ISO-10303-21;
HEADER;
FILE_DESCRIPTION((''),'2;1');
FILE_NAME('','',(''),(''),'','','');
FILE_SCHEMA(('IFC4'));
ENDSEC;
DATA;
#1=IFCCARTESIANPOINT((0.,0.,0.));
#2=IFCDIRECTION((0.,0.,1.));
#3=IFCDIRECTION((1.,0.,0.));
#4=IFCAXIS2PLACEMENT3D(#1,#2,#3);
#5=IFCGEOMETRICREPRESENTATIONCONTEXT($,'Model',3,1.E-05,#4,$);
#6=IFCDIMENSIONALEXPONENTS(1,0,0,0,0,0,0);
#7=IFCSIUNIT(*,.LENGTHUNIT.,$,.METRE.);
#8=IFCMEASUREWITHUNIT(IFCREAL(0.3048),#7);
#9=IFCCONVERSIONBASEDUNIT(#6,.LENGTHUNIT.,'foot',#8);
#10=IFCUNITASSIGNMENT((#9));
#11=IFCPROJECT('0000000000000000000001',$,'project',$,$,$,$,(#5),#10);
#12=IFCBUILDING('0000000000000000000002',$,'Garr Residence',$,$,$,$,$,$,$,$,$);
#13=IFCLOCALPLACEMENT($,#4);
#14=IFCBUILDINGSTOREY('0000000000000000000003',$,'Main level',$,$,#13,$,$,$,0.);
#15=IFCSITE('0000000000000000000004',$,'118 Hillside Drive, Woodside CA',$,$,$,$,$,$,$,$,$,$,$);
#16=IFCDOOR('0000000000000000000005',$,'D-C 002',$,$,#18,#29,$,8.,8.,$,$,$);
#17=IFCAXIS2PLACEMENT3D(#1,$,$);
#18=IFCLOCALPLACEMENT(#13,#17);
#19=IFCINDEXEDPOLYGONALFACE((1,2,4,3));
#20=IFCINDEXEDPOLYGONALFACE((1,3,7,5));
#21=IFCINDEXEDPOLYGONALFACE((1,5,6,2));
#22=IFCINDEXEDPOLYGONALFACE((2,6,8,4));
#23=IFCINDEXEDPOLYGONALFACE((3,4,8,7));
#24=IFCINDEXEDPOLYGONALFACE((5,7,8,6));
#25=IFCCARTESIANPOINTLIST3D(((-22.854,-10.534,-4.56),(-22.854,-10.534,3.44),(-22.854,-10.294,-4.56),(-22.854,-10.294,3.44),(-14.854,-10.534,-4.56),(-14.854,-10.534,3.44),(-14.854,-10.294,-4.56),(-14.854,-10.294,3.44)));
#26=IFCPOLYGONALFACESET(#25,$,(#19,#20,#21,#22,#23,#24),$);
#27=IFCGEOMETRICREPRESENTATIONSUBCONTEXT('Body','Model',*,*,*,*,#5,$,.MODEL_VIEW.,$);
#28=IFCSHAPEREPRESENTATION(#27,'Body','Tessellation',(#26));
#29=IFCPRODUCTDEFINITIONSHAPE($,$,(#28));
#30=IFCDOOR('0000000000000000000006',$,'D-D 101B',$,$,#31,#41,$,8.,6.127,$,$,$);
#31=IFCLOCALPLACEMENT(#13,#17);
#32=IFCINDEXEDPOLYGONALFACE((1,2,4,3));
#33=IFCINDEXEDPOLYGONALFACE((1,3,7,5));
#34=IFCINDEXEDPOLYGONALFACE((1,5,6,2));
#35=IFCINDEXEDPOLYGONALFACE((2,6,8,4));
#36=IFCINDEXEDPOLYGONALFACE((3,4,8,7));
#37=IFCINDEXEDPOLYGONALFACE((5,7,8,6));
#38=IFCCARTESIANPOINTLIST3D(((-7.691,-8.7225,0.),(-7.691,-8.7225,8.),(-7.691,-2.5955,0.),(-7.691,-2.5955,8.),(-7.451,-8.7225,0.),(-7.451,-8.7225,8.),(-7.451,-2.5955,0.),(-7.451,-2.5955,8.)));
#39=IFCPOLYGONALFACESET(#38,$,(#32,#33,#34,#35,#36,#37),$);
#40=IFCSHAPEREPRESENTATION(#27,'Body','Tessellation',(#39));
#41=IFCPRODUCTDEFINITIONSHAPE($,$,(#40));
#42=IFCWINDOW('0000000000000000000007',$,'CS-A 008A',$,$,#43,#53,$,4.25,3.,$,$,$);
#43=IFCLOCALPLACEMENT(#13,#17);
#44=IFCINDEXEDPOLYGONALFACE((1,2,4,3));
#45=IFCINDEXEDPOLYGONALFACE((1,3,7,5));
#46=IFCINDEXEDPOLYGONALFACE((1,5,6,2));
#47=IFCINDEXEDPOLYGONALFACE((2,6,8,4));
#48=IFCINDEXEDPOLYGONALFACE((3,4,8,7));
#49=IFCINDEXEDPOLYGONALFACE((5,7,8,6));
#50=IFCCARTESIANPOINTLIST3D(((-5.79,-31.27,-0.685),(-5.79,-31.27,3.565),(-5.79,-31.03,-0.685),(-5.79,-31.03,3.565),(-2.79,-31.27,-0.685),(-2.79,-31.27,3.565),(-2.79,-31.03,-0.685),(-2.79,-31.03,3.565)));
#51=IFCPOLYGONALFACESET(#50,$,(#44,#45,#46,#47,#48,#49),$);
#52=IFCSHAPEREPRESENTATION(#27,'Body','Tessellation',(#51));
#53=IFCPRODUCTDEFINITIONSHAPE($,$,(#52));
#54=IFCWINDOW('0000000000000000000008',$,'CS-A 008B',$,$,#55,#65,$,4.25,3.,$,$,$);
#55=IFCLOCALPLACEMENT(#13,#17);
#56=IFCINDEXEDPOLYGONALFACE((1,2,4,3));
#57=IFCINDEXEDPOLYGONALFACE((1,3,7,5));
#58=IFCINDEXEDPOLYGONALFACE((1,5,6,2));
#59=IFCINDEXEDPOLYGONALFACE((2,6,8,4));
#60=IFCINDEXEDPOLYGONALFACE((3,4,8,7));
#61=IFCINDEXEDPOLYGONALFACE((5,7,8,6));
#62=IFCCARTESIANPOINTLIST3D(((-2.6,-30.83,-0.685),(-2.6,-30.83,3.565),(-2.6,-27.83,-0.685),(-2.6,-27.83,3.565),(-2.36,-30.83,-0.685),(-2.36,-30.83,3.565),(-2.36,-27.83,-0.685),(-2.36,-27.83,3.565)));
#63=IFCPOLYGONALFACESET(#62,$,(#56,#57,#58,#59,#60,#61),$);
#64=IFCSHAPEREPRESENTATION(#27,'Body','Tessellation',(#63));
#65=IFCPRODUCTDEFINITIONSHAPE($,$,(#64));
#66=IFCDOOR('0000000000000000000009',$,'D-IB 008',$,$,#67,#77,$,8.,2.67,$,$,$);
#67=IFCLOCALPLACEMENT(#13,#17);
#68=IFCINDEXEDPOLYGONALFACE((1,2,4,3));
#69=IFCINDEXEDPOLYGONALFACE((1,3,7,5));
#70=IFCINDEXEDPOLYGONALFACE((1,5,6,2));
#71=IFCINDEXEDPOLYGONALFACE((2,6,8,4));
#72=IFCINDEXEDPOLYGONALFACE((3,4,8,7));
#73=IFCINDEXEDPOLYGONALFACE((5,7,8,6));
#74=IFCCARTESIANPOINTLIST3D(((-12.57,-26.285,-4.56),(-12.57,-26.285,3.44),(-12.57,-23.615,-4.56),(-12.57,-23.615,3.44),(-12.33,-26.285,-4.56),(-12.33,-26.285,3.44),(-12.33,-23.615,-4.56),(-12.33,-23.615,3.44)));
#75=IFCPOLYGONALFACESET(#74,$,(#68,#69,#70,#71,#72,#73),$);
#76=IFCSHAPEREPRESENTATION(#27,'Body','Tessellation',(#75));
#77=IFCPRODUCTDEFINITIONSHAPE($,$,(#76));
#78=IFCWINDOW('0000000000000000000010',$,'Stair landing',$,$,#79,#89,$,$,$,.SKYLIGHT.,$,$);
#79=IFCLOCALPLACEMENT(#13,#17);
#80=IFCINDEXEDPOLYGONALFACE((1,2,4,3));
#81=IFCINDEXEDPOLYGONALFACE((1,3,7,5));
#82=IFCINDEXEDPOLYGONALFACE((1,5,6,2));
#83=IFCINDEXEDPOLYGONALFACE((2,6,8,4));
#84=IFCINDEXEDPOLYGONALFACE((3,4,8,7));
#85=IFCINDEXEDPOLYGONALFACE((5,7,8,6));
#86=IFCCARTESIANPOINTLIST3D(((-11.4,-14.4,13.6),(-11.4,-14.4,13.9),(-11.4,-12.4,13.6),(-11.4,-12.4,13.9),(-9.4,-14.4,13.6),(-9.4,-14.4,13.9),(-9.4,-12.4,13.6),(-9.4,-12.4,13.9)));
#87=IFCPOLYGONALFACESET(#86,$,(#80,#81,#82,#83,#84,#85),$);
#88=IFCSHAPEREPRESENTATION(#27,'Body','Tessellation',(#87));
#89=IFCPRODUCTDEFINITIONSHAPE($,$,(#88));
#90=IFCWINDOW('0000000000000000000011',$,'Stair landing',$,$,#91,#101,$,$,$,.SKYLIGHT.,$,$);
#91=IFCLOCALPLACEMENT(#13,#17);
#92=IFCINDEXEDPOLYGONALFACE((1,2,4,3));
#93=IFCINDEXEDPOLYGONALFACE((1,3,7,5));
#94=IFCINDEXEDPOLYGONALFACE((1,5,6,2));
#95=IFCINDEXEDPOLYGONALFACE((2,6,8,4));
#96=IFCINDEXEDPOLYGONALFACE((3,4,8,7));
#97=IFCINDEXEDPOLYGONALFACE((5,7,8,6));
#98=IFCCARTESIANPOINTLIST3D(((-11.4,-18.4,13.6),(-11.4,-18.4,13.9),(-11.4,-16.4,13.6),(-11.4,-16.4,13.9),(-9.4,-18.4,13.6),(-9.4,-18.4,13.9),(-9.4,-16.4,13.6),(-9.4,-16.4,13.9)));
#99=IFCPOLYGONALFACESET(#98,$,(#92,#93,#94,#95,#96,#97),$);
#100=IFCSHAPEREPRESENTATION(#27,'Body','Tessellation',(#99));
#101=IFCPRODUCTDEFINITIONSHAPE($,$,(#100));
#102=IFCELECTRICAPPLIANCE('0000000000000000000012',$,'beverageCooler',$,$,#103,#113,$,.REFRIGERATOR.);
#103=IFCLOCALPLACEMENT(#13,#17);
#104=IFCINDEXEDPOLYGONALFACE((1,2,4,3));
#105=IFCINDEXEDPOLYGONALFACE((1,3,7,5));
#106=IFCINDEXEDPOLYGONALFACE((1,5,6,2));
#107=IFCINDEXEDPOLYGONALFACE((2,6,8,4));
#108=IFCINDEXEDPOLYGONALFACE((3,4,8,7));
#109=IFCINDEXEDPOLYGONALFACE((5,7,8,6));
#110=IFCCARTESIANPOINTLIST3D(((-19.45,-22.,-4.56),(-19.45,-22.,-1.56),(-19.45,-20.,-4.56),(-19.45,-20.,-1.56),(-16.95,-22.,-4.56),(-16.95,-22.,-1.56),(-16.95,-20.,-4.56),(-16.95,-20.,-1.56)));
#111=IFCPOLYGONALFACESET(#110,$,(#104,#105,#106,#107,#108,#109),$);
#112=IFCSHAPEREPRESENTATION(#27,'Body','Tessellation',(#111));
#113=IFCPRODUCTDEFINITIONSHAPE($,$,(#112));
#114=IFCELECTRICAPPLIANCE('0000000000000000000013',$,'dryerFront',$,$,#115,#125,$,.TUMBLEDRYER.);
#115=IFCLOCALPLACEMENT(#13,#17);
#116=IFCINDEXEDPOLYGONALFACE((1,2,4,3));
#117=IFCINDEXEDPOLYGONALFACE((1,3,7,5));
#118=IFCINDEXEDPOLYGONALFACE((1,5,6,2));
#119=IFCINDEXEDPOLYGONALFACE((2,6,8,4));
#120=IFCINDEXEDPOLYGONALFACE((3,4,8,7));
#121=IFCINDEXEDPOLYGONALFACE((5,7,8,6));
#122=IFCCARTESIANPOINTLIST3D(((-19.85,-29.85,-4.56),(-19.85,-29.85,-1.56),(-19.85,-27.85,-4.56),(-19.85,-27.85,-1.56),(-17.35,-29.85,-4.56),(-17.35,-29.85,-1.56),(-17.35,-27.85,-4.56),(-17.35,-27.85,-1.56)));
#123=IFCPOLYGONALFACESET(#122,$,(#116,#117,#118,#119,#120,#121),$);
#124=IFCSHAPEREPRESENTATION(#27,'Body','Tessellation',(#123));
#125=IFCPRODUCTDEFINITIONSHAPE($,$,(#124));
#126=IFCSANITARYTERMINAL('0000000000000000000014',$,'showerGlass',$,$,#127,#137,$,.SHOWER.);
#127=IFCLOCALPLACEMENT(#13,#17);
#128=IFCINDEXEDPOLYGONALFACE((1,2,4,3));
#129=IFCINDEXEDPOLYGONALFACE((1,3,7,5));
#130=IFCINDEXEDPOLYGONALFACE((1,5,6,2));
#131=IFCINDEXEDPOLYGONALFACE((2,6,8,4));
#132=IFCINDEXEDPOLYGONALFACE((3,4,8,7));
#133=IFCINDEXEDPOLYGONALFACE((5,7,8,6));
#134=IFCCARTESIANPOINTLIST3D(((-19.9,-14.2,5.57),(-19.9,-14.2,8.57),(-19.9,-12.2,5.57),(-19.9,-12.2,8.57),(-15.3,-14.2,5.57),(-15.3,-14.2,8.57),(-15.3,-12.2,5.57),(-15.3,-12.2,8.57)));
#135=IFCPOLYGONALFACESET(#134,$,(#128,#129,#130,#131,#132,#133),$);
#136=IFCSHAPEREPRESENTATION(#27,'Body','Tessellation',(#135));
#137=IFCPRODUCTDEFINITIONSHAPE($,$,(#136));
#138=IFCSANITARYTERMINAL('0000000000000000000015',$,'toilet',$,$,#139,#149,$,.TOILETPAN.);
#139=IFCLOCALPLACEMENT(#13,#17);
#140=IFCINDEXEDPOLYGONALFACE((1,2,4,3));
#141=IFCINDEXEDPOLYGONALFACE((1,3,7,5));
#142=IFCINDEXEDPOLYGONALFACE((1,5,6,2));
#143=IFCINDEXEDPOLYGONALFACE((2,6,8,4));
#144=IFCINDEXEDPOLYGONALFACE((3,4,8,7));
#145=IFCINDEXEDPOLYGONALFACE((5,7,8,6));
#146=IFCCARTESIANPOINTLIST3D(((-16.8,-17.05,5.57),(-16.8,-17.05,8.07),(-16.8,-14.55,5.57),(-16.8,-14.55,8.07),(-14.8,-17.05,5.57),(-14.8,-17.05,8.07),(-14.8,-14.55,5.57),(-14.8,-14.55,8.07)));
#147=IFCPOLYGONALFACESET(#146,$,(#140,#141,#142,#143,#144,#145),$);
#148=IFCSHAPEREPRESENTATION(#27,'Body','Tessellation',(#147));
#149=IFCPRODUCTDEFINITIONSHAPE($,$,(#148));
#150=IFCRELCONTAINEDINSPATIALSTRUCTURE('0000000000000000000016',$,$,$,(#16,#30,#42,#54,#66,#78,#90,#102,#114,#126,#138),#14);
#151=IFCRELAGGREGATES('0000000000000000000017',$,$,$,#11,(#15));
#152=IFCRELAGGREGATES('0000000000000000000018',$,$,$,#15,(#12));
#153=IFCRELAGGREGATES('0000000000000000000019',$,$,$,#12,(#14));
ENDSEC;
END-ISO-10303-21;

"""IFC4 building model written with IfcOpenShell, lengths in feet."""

from ifc_helpers import new_model, entity, si_unit, converted_unit, frame, origin, origin_with_axes, place, context, subcontext, project, spatial, polyline, outline, extrude, element, save


model = new_model("IFC4")

# Units and contexts
model_context = context("Model", 3, precision=1e-05, world=origin_with_axes())
body_context = subcontext(model_context, "Body", "Model", "MODEL_VIEW")
ifc_project = project(units=[converted_unit("LENGTHUNIT", "foot", entity("IfcReal", 0.3048), si_unit("LENGTHUNIT", "METRE"), dimensions=[1, 0, 0, 0, 0, 0, 0])], contexts=[model_context])

# Site, building, storey
site = spatial("IfcSite", under=ifc_project, Name="118 Hillside Drive, Woodside CA")
building = spatial("IfcBuilding", under=site, Name="Garr Residence")
storey_placement = place(None, origin_with_axes())
storey = spatial("IfcBuildingStorey", under=building, at=storey_placement, Name="Main level", Elevation=0.0)

# Doors
door_1_placement = place(storey_placement, frame((-18.854, -10.414, -4.56), z_axis=(0.0, 0.0, 1.0), x_axis=(1.0, 0.0, 0.0)))
element("IfcDoor", 1, at=door_1_placement, inside=storey, Name="D-C 002", OverallHeight=8.0, OverallWidth=8.0, context=body_context, shape_type="SweptSolid", body=[
    extrude(outline(polyline([(-4.0, -0.12), (4.0, -0.12), (4.0, 0.12), (-4.0, 0.12), (-4.0, -0.12)])), origin(), (0.0, 0.0, 1.0), 8.0),
])
door_2_placement = place(storey_placement, frame((-7.571, -5.659, 0.0), z_axis=(0.0, 0.0, 1.0), x_axis=(0.0, 1.0, 0.0)))
element("IfcDoor", 2, at=door_2_placement, inside=storey, Name="D-D 101B", OverallHeight=8.0, OverallWidth=6.127, context=body_context, shape_type="SweptSolid", body=[
    extrude(outline(polyline([(-3.0635, -0.12), (3.0635, -0.12), (3.0635, 0.12), (-3.0635, 0.12), (-3.0635, -0.12)])), origin(), (0.0, 0.0, 1.0), 8.0),
])

# Windows
for number, where, z_axis, x_axis, name in (
    (3, (-4.29, -31.15, -0.685), (0.0, 0.0, 1.0), (1.0, 0.0, 0.0), "CS-A 008A"),
    (4, (-2.48, -29.33, -0.685), (0.0, 0.0, 1.0), (0.0, 1.0, 0.0), "CS-A 008B"),
):
    element("IfcWindow", number, at=place(storey_placement, frame(where, z_axis=z_axis, x_axis=x_axis)), inside=storey, Name=name, OverallHeight=4.25, OverallWidth=3.0, context=body_context, shape_type="SweptSolid", body=[
        extrude(outline(polyline([(-1.5, -0.12), (1.5, -0.12), (1.5, 0.12), (-1.5, 0.12), (-1.5, -0.12)])), origin(), (0.0, 0.0, 1.0), 4.25),
    ])

# Door
door_3_placement = place(storey_placement, frame((-12.45, -24.95, -4.56), z_axis=(0.0, 0.0, 1.0), x_axis=(0.0, 1.0, 0.0)))
element("IfcDoor", 5, at=door_3_placement, inside=storey, Name="D-IB 008", OverallHeight=8.0, OverallWidth=2.67, context=body_context, shape_type="SweptSolid", body=[
    extrude(outline(polyline([(-1.335, -0.12), (1.335, -0.12), (1.335, 0.12), (-1.335, 0.12), (-1.335, -0.12)])), origin(), (0.0, 0.0, 1.0), 8.0),
])

# Windows
for number, where, z_axis, x_axis, name in (
    (6, (-10.4, -13.4, 13.6), (0.0, 0.0, 1.0), (1.0, 0.0, 0.0), "Stair landing"),
    (7, (-10.4, -17.4, 13.6), (0.0, 0.0, 1.0), (1.0, 0.0, 0.0), "Stair landing"),
):
    element("IfcWindow", number, at=place(storey_placement, frame(where, z_axis=z_axis, x_axis=x_axis)), inside=storey, Name=name, PredefinedType="SKYLIGHT", context=body_context, shape_type="SweptSolid", body=[
        extrude(outline(polyline([(-1.0, -1.0), (1.0, -1.0), (1.0, 1.0), (-1.0, 1.0), (-1.0, -1.0)])), origin(), (0.0, 0.0, 1.0), 0.3),
    ])

# Electric appliances
electric_appliance_1_placement = place(storey_placement, frame((-18.2, -22.0, -4.56), z_axis=(0.0, 0.0, 1.0), x_axis=(1.0, 0.0, 0.0)))
element("IfcElectricAppliance", 8, at=electric_appliance_1_placement, inside=storey, Name="beverageCooler", PredefinedType="REFRIGERATOR", context=body_context, shape_type="SweptSolid", body=[
    extrude(outline(polyline([(-1.25, 0.0), (1.25, 0.0), (1.25, 2.0), (-1.25, 2.0), (-1.25, 0.0)])), origin(), (0.0, 0.0, 1.0), 3.0),
])
electric_appliance_2_placement = place(storey_placement, frame((-18.6, -29.85, -4.56), z_axis=(0.0, 0.0, 1.0), x_axis=(1.0, 0.0, 0.0)))
element("IfcElectricAppliance", 9, at=electric_appliance_2_placement, inside=storey, Name="dryerFront", PredefinedType="TUMBLEDRYER", context=body_context, shape_type="SweptSolid", body=[
    extrude(outline(polyline([(-1.25, 0.0), (1.25, 0.0), (1.25, 2.0), (-1.25, 2.0), (-1.25, 0.0)])), origin(), (0.0, 0.0, 1.0), 3.0),
])

# Sanitary terminals
sanitary_terminal_1_placement = place(storey_placement, frame((-17.6, -14.2, 5.57), z_axis=(0.0, 0.0, 1.0), x_axis=(1.0, 0.0, 0.0)))
element("IfcSanitaryTerminal", 10, at=sanitary_terminal_1_placement, inside=storey, Name="showerGlass", PredefinedType="SHOWER", context=body_context, shape_type="SweptSolid", body=[
    extrude(outline(polyline([(-2.3, 0.0), (2.3, 0.0), (2.3, 2.0), (-2.3, 2.0), (-2.3, 0.0)])), origin(), (0.0, 0.0, 1.0), 3.0),
])
sanitary_terminal_2_placement = place(storey_placement, frame((-14.8, -15.8, 5.57), z_axis=(0.0, 0.0, 1.0), x_axis=(0.0, 1.0, 0.0)))
element("IfcSanitaryTerminal", 11, at=sanitary_terminal_2_placement, inside=storey, Name="toilet", PredefinedType="TOILETPAN", context=body_context, shape_type="SweptSolid", body=[
    extrude(outline(polyline([(-1.25, 0.0), (1.25, 0.0), (1.25, 2.0), (-1.25, 2.0), (-1.25, 0.0)])), origin(), (0.0, 0.0, 1.0), 2.5),
])

save(model, "model.ifc")
